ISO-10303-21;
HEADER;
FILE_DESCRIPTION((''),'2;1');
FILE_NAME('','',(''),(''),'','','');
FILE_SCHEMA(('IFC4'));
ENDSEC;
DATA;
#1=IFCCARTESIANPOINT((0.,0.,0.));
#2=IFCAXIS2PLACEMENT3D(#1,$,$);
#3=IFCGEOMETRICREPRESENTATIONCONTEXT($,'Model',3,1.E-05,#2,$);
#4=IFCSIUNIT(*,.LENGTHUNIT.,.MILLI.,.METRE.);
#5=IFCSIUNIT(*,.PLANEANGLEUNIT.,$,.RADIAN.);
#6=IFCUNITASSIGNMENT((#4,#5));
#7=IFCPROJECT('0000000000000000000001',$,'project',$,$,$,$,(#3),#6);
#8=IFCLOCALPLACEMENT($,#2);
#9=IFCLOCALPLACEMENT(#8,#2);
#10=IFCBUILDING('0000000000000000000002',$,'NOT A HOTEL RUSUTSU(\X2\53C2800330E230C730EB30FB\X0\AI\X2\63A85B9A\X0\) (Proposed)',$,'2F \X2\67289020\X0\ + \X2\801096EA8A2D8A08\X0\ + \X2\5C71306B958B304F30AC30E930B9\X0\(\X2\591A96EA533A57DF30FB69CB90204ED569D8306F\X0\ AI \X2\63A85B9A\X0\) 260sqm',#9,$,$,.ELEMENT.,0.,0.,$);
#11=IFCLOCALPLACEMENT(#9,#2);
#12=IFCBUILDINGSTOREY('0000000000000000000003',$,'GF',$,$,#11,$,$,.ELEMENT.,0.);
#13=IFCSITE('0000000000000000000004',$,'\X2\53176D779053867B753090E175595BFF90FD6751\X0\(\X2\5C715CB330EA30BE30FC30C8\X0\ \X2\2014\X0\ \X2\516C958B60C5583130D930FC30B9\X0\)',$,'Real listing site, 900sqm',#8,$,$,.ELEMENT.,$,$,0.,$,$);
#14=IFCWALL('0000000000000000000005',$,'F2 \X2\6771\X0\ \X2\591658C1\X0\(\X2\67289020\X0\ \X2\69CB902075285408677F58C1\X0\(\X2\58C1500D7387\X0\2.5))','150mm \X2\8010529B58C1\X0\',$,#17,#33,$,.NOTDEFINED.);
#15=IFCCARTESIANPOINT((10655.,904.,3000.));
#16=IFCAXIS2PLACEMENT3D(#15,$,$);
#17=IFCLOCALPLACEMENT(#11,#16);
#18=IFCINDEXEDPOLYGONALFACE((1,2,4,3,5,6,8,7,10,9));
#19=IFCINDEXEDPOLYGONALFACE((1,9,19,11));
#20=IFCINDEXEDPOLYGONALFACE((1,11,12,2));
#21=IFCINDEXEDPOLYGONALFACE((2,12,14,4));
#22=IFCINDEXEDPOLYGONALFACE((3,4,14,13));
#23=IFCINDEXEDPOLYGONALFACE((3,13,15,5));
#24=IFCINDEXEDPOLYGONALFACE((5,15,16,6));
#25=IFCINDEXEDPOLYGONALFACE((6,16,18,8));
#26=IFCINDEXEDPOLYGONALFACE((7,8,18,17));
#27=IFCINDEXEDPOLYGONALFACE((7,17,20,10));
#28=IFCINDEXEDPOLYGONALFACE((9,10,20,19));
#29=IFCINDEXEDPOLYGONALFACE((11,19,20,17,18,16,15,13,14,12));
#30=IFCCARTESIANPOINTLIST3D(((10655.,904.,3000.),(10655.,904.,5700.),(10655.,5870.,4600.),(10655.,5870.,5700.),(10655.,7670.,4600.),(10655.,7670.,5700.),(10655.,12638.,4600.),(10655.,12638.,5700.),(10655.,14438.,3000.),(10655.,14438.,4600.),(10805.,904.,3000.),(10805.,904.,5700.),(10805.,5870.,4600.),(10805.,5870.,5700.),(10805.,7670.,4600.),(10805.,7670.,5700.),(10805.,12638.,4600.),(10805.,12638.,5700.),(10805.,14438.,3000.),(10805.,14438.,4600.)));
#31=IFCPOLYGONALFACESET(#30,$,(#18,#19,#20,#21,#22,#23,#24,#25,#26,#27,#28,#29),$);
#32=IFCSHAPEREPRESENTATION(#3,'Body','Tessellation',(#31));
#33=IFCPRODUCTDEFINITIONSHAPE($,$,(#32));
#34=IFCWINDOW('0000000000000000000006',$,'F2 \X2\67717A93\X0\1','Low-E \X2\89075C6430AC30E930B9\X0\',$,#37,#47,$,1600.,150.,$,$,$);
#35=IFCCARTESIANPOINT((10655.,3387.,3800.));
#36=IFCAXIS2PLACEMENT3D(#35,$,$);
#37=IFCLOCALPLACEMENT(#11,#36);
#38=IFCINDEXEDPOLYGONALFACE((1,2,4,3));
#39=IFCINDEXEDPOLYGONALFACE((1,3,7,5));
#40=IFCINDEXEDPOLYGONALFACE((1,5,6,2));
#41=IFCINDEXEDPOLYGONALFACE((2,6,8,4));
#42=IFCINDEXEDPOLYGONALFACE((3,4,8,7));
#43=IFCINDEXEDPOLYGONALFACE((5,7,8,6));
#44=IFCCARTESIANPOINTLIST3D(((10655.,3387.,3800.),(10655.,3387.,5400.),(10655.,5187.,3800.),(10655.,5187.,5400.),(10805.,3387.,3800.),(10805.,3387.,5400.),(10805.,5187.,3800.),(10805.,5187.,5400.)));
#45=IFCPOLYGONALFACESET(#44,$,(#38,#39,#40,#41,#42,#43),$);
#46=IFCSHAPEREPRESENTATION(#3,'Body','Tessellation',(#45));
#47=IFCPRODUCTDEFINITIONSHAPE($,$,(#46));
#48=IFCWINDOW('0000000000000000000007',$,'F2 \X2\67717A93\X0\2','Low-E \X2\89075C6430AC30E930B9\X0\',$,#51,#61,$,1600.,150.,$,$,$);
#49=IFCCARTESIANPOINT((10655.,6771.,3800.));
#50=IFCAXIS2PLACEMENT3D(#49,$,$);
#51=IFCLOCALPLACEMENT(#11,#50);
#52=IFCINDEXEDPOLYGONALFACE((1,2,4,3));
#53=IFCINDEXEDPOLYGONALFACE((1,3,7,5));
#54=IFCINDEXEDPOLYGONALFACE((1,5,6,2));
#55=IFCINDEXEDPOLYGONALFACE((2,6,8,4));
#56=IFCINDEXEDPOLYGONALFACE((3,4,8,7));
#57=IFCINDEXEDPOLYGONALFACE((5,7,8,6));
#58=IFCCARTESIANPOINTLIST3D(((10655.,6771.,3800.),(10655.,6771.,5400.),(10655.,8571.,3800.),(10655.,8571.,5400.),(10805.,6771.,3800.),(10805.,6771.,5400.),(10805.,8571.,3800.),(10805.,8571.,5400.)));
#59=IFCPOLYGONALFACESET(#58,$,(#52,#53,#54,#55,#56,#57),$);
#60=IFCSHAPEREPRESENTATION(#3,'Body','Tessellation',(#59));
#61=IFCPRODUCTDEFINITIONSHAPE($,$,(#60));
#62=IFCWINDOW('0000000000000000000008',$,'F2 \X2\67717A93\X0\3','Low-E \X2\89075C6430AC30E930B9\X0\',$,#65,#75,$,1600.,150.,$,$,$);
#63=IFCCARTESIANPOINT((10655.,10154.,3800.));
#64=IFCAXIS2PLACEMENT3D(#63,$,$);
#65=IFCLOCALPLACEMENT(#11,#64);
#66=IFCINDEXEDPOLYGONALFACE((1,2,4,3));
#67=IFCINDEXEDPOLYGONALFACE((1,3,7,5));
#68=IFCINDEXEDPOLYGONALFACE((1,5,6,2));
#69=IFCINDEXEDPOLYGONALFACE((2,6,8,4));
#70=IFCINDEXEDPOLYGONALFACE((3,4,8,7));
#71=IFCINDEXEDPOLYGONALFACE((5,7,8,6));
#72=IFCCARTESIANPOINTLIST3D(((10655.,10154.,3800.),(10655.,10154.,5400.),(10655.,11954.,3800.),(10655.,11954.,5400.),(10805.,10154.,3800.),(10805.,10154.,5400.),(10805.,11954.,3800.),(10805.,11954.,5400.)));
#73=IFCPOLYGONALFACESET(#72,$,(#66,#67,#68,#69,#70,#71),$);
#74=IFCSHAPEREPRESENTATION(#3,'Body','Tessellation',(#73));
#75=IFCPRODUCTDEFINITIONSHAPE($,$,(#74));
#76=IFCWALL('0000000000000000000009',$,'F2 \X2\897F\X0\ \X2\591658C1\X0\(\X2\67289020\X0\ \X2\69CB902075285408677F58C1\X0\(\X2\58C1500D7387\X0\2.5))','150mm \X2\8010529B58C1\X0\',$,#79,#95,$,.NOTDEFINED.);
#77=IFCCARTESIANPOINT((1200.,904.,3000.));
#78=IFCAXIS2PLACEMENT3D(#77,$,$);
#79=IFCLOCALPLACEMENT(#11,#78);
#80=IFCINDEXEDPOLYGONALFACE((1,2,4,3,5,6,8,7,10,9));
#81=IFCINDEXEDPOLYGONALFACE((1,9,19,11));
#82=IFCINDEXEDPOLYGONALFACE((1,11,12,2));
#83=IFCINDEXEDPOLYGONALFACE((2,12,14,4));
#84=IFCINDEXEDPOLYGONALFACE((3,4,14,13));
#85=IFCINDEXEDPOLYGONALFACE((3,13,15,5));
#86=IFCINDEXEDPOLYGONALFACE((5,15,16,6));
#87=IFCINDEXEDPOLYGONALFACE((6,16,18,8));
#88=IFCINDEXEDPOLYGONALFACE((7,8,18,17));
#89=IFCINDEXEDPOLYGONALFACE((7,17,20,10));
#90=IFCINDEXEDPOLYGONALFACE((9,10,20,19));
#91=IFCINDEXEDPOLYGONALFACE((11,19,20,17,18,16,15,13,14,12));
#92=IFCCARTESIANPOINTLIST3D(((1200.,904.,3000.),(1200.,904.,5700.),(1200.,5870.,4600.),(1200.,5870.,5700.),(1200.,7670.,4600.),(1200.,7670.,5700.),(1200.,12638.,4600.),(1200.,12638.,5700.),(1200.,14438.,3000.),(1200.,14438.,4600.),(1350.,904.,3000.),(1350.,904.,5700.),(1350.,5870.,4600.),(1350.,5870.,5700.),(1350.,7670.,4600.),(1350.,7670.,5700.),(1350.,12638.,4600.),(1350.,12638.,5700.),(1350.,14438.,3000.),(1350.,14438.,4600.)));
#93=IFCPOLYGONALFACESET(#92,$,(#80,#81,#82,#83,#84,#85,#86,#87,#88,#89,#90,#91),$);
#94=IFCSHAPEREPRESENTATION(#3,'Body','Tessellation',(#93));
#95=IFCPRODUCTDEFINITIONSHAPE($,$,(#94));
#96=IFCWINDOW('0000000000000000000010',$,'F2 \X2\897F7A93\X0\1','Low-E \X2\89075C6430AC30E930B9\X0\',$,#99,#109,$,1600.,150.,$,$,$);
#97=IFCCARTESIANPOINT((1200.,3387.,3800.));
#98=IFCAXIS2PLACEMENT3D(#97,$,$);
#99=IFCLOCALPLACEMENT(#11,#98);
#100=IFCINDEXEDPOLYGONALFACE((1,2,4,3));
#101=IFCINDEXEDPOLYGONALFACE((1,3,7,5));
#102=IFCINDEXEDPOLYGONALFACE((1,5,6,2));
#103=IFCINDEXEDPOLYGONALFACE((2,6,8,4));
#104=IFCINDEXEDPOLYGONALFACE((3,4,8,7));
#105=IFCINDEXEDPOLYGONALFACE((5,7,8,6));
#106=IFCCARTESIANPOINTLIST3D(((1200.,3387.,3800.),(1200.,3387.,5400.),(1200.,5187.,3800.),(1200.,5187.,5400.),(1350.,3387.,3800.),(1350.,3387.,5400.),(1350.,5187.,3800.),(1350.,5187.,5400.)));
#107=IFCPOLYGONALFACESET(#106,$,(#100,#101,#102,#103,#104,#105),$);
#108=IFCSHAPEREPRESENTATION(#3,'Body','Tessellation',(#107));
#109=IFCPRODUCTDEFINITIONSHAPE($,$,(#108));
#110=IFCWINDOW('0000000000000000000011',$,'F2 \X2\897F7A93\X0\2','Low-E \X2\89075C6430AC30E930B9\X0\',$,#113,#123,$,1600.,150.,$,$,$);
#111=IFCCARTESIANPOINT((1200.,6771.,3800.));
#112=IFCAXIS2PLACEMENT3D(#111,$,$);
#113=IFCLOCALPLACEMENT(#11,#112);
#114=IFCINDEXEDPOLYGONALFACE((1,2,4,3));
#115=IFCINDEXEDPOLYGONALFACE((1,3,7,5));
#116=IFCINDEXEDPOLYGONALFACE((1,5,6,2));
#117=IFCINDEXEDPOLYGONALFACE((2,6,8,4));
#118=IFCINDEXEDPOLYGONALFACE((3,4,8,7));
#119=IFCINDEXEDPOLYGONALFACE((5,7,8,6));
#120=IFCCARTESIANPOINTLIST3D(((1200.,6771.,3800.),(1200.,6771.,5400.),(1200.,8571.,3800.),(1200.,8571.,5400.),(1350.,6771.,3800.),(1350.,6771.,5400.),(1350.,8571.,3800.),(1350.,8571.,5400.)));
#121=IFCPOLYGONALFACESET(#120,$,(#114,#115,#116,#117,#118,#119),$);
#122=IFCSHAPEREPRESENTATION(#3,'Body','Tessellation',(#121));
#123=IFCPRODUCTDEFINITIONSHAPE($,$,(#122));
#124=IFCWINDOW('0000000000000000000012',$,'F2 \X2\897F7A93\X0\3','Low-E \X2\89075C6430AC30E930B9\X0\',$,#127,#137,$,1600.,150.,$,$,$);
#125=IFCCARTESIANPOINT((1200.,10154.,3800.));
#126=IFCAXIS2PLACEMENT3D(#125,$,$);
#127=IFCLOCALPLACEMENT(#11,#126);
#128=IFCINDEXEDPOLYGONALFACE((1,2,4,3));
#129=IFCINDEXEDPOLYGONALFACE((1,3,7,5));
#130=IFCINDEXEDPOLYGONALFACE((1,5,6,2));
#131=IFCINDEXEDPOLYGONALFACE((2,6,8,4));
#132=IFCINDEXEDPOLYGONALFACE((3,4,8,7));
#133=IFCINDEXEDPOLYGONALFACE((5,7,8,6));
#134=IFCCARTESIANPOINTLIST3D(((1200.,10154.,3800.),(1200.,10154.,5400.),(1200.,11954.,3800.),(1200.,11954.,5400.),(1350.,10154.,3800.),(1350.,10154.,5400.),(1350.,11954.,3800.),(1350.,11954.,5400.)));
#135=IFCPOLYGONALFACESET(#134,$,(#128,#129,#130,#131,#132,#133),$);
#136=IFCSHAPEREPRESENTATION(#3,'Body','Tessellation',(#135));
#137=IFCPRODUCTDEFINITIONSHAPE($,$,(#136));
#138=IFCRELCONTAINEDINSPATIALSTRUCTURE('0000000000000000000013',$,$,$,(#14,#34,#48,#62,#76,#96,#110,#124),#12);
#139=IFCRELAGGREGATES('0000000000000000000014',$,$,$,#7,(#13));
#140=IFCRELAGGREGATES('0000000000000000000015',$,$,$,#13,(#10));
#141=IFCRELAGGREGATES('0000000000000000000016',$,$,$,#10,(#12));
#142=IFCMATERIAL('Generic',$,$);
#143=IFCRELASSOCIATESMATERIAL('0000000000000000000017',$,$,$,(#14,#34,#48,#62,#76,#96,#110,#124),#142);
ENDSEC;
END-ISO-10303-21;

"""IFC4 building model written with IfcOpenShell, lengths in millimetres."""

from ifc_helpers import new_model, si_unit, frame, frame_2d, origin, place, context, project, spatial, rectangle, extrude, material, element, fill, save


model = new_model("IFC4")

# Units and contexts
model_context = context("Model", 3, precision=1e-05, world=origin())
ifc_project = project(units=[si_unit("LENGTHUNIT", "METRE", prefix="MILLI"), si_unit("PLANEANGLEUNIT", "RADIAN")], contexts=[model_context])

# Site, building, storey
site_placement = place(None, origin())
site = spatial("IfcSite", under=ifc_project, at=site_placement, Name="北海道虻田郡留寿都村(山岳リゾート — 公開情報ベース)", ObjectType="Real listing site, 900sqm", CompositionType="ELEMENT", RefElevation=0.0)
building_placement = place(site_placement, origin())
building = spatial("IfcBuilding", under=site, at=building_placement, Name="NOT A HOTEL RUSUTSU(参考モデル・AI推定) (Proposed)", ObjectType="2F 木造 + 耐雪設計 + 山に開くガラス(多雪区域・構造仕様は AI 推定) 260sqm", CompositionType="ELEMENT", ElevationOfRefHeight=0.0, ElevationOfTerrain=0.0)
storey_placement = place(building_placement, origin())
storey = spatial("IfcBuildingStorey", under=building, at=storey_placement, Name="GF", CompositionType="ELEMENT", Elevation=0.0)

# Shared definitions
ifc_material = material(Name="Generic")

# Walls, openings, windows
wall_1_placement = place(storey_placement, frame((10655.0, 904.0, 3000.0)))
wall_1 = element("IfcWall", 1, at=wall_1_placement, inside=storey, material=ifc_material, Name="F2 東 外壁(木造 構造用合板壁(壁倍率2.5))", Description="150mm 耐力壁", PredefinedType="NOTDEFINED", context=model_context, shape_type="SweptSolid", body=[
    extrude(rectangle(XDim=150.0, YDim=13534.0, at=frame_2d((75.0, 6767.0))), frame((10655.0, 904.0, 3000.0)), (0.0, 0.0, 1.0), 2700.0),
])
opening_1_placement = place(storey_placement, frame((10655.0, 3387.0, 3800.0)))
opening_1 = element("IfcOpeningElement", 2, at=opening_1_placement, cuts=wall_1, PredefinedType="NOTDEFINED", context=model_context, shape_type="SweptSolid", body=[
    extrude(rectangle(XDim=150.0, YDim=1800.0, at=frame_2d((75.0, 900.0))), frame((10655.0, 3387.0, 3800.0)), (0.0, 0.0, 1.0), 1600.0),
])
opening_2_placement = place(storey_placement, frame((10655.0, 6771.0, 3800.0)))
opening_2 = element("IfcOpeningElement", 3, at=opening_2_placement, cuts=wall_1, PredefinedType="NOTDEFINED", context=model_context, shape_type="SweptSolid", body=[
    extrude(rectangle(XDim=150.0, YDim=1800.0, at=frame_2d((75.0, 900.0))), frame((10655.0, 6771.0, 3800.0)), (0.0, 0.0, 1.0), 1600.0),
])
opening_3_placement = place(storey_placement, frame((10655.0, 10154.0, 3800.0)))
opening_3 = element("IfcOpeningElement", 4, at=opening_3_placement, cuts=wall_1, PredefinedType="NOTDEFINED", context=model_context, shape_type="SweptSolid", body=[
    extrude(rectangle(XDim=150.0, YDim=1800.0, at=frame_2d((75.0, 900.0))), frame((10655.0, 10154.0, 3800.0)), (0.0, 0.0, 1.0), 1600.0),
])
window_1_placement = place(storey_placement, frame((10655.0, 3387.0, 3800.0)))
window_1 = element("IfcWindow", 5, at=window_1_placement, inside=storey, material=ifc_material, Name="F2 東窓1", Description="Low-E 複層ガラス", OverallHeight=1600.0, OverallWidth=150.0, context=model_context, shape_type="SweptSolid", body=[
    extrude(rectangle(XDim=150.0, YDim=1800.0, at=frame_2d((75.0, 900.0))), frame((10655.0, 3387.0, 3800.0)), (0.0, 0.0, 1.0), 1600.0),
])
fill(opening_1, window_1)
window_2_placement = place(storey_placement, frame((10655.0, 6771.0, 3800.0)))
window_2 = element("IfcWindow", 6, at=window_2_placement, inside=storey, material=ifc_material, Name="F2 東窓2", Description="Low-E 複層ガラス", OverallHeight=1600.0, OverallWidth=150.0, context=model_context, shape_type="SweptSolid", body=[
    extrude(rectangle(XDim=150.0, YDim=1800.0, at=frame_2d((75.0, 900.0))), frame((10655.0, 6771.0, 3800.0)), (0.0, 0.0, 1.0), 1600.0),
])
fill(opening_2, window_2)
window_3_placement = place(storey_placement, frame((10655.0, 10154.0, 3800.0)))
window_3 = element("IfcWindow", 7, at=window_3_placement, inside=storey, material=ifc_material, Name="F2 東窓3", Description="Low-E 複層ガラス", OverallHeight=1600.0, OverallWidth=150.0, context=model_context, shape_type="SweptSolid", body=[
    extrude(rectangle(XDim=150.0, YDim=1800.0, at=frame_2d((75.0, 900.0))), frame((10655.0, 10154.0, 3800.0)), (0.0, 0.0, 1.0), 1600.0),
])
fill(opening_3, window_3)
wall_2_placement = place(storey_placement, frame((1200.0, 904.0, 3000.0)))
wall_2 = element("IfcWall", 8, at=wall_2_placement, inside=storey, material=ifc_material, Name="F2 西 外壁(木造 構造用合板壁(壁倍率2.5))", Description="150mm 耐力壁", PredefinedType="NOTDEFINED", context=model_context, shape_type="SweptSolid", body=[
    extrude(rectangle(XDim=150.0, YDim=13534.0, at=frame_2d((75.0, 6767.0))), frame((1200.0, 904.0, 3000.0)), (0.0, 0.0, 1.0), 2700.0),
])
opening_4_placement = place(storey_placement, frame((1200.0, 3387.0, 3800.0)))
opening_4 = element("IfcOpeningElement", 9, at=opening_4_placement, cuts=wall_2, PredefinedType="NOTDEFINED", context=model_context, shape_type="SweptSolid", body=[
    extrude(rectangle(XDim=150.0, YDim=1800.0, at=frame_2d((75.0, 900.0))), frame((1200.0, 3387.0, 3800.0)), (0.0, 0.0, 1.0), 1600.0),
])
opening_5_placement = place(storey_placement, frame((1200.0, 6771.0, 3800.0)))
opening_5 = element("IfcOpeningElement", 10, at=opening_5_placement, cuts=wall_2, PredefinedType="NOTDEFINED", context=model_context, shape_type="SweptSolid", body=[
    extrude(rectangle(XDim=150.0, YDim=1800.0, at=frame_2d((75.0, 900.0))), frame((1200.0, 6771.0, 3800.0)), (0.0, 0.0, 1.0), 1600.0),
])
opening_6_placement = place(storey_placement, frame((1200.0, 10154.0, 3800.0)))
opening_6 = element("IfcOpeningElement", 11, at=opening_6_placement, cuts=wall_2, PredefinedType="NOTDEFINED", context=model_context, shape_type="SweptSolid", body=[
    extrude(rectangle(XDim=150.0, YDim=1800.0, at=frame_2d((75.0, 900.0))), frame((1200.0, 10154.0, 3800.0)), (0.0, 0.0, 1.0), 1600.0),
])
window_4_placement = place(storey_placement, frame((1200.0, 3387.0, 3800.0)))
window_4 = element("IfcWindow", 12, at=window_4_placement, inside=storey, material=ifc_material, Name="F2 西窓1", Description="Low-E 複層ガラス", OverallHeight=1600.0, OverallWidth=150.0, context=model_context, shape_type="SweptSolid", body=[
    extrude(rectangle(XDim=150.0, YDim=1800.0, at=frame_2d((75.0, 900.0))), frame((1200.0, 3387.0, 3800.0)), (0.0, 0.0, 1.0), 1600.0),
])
fill(opening_4, window_4)
window_5_placement = place(storey_placement, frame((1200.0, 6771.0, 3800.0)))
window_5 = element("IfcWindow", 13, at=window_5_placement, inside=storey, material=ifc_material, Name="F2 西窓2", Description="Low-E 複層ガラス", OverallHeight=1600.0, OverallWidth=150.0, context=model_context, shape_type="SweptSolid", body=[
    extrude(rectangle(XDim=150.0, YDim=1800.0, at=frame_2d((75.0, 900.0))), frame((1200.0, 6771.0, 3800.0)), (0.0, 0.0, 1.0), 1600.0),
])
fill(opening_5, window_5)
window_6_placement = place(storey_placement, frame((1200.0, 10154.0, 3800.0)))
window_6 = element("IfcWindow", 14, at=window_6_placement, inside=storey, material=ifc_material, Name="F2 西窓3", Description="Low-E 複層ガラス", OverallHeight=1600.0, OverallWidth=150.0, context=model_context, shape_type="SweptSolid", body=[
    extrude(rectangle(XDim=150.0, YDim=1800.0, at=frame_2d((75.0, 900.0))), frame((1200.0, 10154.0, 3800.0)), (0.0, 0.0, 1.0), 1600.0),
])
fill(opening_6, window_6)

save(model, "model.ifc")
